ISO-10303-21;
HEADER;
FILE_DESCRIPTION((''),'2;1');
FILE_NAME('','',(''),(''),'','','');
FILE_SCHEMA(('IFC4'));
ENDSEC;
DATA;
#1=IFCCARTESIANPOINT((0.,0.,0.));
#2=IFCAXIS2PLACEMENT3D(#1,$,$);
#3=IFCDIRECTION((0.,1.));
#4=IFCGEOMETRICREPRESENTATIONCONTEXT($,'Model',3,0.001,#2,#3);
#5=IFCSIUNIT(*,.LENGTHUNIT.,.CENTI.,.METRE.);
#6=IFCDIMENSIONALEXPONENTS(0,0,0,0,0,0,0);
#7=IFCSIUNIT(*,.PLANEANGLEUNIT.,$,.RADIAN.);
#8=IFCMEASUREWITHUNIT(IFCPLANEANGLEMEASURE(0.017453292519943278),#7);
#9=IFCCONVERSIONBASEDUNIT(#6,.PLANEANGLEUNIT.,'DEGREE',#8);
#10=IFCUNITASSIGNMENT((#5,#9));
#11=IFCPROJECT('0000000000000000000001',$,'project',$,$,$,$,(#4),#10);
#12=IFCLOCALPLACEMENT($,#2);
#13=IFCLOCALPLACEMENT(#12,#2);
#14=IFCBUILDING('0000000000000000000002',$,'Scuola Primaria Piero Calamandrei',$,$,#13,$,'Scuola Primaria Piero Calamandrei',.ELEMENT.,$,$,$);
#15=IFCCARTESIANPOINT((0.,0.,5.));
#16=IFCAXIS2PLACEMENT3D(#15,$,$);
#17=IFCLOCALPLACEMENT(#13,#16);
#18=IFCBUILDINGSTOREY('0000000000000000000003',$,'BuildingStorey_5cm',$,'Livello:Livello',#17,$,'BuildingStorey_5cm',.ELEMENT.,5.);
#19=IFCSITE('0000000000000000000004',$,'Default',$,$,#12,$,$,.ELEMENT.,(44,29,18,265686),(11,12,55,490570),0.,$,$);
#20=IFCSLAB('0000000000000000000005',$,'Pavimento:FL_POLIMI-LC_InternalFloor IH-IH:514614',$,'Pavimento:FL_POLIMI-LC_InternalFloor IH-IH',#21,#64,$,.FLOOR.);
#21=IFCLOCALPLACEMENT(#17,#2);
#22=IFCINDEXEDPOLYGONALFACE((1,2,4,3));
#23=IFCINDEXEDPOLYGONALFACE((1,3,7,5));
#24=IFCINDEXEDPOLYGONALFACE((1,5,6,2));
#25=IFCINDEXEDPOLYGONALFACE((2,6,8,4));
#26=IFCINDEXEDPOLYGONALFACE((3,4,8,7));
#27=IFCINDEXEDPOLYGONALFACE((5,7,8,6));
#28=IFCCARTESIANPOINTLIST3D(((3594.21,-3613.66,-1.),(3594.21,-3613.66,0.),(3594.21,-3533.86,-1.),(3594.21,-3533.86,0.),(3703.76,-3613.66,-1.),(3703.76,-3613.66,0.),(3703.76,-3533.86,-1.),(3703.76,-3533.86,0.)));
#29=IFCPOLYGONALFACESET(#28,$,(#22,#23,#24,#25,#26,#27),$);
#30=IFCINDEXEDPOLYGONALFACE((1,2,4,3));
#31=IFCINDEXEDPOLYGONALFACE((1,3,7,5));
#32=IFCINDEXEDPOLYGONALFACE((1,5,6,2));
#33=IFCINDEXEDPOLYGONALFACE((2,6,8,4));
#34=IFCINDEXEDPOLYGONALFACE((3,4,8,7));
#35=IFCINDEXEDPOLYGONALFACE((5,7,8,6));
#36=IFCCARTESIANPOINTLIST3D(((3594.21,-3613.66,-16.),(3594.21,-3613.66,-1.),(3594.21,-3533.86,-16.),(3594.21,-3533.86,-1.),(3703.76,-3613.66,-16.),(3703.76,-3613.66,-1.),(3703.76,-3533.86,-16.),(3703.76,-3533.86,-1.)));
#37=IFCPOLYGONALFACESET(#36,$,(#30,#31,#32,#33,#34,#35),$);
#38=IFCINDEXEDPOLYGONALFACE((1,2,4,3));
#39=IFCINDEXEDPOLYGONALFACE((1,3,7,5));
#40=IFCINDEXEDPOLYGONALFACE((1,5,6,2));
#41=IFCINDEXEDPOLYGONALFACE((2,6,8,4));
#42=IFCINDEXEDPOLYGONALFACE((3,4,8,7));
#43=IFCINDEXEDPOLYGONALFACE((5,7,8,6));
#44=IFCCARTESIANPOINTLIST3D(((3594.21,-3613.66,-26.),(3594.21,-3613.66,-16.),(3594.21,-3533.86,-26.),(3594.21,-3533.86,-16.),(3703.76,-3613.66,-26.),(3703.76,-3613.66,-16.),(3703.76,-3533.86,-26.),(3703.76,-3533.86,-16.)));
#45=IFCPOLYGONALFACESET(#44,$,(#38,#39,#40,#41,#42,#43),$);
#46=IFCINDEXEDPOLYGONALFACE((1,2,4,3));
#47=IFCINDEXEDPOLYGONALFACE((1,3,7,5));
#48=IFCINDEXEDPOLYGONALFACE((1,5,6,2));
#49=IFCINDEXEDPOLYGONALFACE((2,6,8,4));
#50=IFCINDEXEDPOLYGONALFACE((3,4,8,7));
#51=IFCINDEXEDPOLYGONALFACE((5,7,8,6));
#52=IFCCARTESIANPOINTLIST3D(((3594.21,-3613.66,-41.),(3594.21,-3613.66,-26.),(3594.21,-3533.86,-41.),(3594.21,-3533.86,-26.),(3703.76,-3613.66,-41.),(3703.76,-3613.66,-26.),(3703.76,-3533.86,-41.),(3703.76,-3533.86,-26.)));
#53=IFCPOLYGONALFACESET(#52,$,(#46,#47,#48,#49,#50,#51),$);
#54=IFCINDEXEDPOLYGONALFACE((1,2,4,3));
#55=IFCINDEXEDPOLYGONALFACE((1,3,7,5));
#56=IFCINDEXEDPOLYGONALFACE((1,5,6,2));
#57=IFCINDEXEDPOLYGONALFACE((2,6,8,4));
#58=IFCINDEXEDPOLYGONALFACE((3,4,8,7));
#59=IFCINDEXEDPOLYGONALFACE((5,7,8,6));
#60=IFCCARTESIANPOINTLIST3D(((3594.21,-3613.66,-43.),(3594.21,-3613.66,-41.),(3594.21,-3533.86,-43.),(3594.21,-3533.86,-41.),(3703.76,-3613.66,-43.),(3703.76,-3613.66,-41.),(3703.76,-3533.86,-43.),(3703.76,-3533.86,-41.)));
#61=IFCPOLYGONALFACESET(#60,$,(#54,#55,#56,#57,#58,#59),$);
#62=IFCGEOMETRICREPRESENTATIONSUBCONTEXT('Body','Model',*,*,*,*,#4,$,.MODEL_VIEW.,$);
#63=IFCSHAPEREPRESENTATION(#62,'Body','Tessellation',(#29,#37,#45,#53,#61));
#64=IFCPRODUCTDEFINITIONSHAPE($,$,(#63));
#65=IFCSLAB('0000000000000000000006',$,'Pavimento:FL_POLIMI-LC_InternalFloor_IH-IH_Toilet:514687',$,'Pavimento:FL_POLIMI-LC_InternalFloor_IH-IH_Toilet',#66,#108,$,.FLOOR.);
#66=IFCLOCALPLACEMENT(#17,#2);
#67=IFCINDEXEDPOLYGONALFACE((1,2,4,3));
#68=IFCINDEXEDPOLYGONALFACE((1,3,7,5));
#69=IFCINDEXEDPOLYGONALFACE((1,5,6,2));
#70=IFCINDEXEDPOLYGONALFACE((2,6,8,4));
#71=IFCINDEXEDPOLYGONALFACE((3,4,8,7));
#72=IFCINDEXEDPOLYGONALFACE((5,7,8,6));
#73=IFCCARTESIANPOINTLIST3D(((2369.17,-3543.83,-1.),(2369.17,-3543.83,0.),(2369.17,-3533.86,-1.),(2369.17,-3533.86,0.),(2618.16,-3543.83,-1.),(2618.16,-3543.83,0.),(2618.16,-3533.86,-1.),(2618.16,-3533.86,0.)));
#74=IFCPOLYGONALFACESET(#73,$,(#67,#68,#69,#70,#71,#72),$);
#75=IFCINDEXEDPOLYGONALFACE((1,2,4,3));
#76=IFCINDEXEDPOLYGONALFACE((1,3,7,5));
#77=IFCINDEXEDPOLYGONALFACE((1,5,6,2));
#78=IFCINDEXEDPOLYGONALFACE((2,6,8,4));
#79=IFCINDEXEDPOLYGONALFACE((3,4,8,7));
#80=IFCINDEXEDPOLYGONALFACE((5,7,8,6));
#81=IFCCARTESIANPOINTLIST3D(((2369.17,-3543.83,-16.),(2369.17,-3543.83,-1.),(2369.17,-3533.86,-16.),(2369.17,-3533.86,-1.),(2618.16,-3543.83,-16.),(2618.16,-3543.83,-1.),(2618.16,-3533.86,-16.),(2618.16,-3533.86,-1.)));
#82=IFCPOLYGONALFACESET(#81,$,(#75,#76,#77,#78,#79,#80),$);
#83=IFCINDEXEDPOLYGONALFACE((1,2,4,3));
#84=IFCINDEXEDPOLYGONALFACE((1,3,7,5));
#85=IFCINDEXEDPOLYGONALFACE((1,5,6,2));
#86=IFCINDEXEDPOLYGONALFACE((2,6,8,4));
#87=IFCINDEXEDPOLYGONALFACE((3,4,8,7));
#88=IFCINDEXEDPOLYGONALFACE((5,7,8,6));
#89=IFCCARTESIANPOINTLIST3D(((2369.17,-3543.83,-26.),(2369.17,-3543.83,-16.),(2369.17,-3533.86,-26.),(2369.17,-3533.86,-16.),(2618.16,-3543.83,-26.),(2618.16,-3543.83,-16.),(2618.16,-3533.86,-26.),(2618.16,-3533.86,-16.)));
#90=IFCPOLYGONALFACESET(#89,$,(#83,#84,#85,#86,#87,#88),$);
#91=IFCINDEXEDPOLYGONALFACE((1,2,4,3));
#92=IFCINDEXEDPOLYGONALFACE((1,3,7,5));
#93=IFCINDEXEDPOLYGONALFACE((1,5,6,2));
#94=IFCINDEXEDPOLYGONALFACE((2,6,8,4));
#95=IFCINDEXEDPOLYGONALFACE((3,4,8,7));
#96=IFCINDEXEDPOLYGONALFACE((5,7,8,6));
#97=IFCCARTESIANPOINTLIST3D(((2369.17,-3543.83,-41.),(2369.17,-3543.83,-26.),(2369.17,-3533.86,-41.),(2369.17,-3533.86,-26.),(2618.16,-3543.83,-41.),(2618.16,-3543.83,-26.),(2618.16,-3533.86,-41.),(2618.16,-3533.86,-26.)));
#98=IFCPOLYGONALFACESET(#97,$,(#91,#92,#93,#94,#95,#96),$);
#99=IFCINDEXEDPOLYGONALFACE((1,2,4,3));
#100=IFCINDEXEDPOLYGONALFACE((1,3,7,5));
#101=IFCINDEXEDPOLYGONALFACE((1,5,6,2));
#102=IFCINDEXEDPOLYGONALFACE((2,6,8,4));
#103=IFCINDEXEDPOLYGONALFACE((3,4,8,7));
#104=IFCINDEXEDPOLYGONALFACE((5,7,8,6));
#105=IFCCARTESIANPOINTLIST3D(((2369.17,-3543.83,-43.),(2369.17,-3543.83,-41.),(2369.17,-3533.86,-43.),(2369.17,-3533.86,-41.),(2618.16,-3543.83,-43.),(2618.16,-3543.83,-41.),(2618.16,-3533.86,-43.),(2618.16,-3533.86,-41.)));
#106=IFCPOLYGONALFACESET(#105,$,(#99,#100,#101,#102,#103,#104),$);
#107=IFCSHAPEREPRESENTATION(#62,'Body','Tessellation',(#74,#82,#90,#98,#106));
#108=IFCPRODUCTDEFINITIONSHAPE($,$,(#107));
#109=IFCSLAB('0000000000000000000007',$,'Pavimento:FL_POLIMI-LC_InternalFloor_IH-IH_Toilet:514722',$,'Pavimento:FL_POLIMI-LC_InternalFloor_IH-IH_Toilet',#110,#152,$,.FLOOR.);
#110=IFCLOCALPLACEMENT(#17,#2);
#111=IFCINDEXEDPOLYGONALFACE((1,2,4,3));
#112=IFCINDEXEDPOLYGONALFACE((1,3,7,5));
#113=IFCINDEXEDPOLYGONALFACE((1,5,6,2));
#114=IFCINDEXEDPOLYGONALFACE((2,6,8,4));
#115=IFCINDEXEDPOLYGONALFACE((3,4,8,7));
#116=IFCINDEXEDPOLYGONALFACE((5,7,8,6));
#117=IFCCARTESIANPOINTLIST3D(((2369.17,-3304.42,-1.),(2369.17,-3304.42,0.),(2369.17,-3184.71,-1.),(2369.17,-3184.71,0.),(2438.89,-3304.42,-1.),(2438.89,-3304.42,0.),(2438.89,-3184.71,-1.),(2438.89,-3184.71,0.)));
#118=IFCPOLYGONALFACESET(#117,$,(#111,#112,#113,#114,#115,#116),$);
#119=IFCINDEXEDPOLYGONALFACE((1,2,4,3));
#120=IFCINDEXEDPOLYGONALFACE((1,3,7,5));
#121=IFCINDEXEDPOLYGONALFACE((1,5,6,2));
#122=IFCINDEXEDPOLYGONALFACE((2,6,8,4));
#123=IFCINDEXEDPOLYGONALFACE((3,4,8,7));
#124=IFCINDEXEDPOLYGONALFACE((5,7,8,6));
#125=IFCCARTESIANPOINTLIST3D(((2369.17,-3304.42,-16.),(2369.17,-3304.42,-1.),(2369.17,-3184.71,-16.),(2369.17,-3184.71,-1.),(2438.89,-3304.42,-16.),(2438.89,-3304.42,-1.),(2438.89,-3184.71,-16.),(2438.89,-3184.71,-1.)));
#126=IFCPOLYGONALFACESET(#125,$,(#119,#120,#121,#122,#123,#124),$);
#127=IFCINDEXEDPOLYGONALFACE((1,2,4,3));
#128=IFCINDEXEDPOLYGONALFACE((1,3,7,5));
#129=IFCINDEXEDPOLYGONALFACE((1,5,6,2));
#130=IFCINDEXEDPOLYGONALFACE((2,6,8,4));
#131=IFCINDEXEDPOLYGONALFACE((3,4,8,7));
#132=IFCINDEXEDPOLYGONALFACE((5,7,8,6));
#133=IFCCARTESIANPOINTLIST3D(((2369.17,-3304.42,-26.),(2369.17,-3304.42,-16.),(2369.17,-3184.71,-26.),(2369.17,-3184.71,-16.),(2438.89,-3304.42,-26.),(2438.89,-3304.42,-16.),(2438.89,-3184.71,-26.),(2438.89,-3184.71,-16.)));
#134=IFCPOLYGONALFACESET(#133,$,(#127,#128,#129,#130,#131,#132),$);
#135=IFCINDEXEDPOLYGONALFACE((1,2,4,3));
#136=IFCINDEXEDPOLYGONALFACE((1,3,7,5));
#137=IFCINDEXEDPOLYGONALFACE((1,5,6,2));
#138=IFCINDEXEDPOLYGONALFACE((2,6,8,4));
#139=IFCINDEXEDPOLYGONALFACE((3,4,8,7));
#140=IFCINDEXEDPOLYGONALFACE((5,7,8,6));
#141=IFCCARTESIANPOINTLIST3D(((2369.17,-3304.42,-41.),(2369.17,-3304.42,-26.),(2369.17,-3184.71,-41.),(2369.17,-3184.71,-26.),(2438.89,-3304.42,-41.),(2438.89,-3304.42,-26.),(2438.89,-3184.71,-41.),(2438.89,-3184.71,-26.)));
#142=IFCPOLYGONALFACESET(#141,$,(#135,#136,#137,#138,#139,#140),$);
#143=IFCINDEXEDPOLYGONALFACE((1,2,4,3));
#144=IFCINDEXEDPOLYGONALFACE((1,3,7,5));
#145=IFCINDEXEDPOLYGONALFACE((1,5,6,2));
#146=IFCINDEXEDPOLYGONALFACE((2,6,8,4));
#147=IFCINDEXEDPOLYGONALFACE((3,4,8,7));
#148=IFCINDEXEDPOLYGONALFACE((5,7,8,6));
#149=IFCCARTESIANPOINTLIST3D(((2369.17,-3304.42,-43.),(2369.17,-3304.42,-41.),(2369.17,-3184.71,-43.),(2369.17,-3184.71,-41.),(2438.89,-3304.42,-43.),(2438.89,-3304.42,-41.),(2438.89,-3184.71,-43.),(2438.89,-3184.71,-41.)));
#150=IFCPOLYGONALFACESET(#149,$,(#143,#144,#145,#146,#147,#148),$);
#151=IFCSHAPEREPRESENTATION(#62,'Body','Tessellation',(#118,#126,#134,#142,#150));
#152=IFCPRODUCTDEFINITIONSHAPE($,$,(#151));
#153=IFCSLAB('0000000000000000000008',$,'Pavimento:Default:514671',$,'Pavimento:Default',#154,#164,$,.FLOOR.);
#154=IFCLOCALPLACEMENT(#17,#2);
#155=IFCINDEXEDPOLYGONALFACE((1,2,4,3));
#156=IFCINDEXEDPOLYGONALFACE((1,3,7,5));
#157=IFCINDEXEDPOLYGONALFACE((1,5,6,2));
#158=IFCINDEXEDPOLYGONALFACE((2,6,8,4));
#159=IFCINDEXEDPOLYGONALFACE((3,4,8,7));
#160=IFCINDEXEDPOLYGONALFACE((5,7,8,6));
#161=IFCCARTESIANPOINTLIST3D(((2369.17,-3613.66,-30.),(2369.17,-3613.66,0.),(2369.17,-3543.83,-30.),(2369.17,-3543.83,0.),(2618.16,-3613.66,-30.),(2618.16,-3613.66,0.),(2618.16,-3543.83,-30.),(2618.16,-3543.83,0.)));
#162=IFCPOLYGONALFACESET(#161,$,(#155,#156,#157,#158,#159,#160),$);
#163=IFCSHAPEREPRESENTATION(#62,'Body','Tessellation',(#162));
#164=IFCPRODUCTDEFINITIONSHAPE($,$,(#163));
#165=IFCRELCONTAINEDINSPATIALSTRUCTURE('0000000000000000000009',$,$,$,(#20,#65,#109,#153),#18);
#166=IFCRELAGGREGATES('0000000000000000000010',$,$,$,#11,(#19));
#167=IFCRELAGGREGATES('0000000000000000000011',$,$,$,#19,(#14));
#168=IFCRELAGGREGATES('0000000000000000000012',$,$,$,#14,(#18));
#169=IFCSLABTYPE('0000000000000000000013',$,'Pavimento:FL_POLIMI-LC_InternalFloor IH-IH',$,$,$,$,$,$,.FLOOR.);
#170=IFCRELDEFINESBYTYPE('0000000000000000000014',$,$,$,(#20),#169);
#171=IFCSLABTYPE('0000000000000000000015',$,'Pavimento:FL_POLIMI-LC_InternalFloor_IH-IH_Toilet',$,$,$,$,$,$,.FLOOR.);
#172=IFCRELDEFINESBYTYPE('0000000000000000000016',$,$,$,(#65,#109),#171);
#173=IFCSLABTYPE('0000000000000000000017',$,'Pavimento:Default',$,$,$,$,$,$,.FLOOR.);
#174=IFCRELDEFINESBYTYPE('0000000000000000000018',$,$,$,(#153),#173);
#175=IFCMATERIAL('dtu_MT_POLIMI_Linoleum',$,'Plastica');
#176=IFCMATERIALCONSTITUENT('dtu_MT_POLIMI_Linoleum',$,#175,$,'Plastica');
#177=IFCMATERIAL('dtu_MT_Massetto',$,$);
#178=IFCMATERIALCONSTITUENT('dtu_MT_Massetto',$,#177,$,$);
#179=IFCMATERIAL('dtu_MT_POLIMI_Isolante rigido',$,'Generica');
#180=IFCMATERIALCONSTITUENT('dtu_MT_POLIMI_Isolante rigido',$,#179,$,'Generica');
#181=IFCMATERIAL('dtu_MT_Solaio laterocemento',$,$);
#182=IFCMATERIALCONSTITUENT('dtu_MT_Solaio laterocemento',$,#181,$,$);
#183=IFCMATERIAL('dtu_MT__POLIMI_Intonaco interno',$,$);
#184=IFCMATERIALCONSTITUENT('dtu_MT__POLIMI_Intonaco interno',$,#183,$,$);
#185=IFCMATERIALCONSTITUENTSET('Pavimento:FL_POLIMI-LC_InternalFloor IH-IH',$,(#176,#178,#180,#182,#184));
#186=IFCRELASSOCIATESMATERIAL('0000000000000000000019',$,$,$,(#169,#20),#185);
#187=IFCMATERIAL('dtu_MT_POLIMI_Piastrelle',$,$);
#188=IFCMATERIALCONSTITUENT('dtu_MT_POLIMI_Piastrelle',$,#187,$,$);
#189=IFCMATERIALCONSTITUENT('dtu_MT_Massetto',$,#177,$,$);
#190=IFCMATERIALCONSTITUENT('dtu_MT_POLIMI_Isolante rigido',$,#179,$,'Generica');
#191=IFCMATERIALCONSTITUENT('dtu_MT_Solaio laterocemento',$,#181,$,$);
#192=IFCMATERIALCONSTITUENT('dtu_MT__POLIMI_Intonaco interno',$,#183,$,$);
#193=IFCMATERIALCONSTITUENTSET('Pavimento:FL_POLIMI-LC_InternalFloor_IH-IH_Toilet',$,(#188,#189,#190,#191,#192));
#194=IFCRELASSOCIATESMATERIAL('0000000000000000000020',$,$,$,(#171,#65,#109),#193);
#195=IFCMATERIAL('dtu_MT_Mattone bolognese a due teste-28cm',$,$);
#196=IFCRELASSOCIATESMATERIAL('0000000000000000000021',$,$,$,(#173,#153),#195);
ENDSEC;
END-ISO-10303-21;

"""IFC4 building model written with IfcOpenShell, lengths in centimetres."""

from ifc_helpers import new_model, entity, si_unit, converted_unit, direction, frame, origin, place, context, subcontext, project, spatial, indexed_curve, outline, extrude, material, constituent, constituent_set, type_object, element, save


model = new_model("IFC4")

# Units and contexts
model_context = context("Model", 3, precision=0.001, world=origin(), true_north=direction((0.0, 1.0)))
body_context = subcontext(model_context, "Body", "Model", "MODEL_VIEW")
ifc_project = project(units=[si_unit("LENGTHUNIT", "METRE", prefix="CENTI"), converted_unit("PLANEANGLEUNIT", "DEGREE", entity("IfcPlaneAngleMeasure", 0.017453292519943278), si_unit("PLANEANGLEUNIT", "RADIAN"), dimensions=[0, 0, 0, 0, 0, 0, 0])], contexts=[model_context])

# Site, building, storey
site_placement = place(None, origin())
site = spatial("IfcSite", under=ifc_project, at=site_placement, Name="Default", CompositionType="ELEMENT", RefLatitude=(44, 29, 18, 265686), RefLongitude=(11, 12, 55, 490570), RefElevation=0.0)
building_placement = place(site_placement, origin())
building = spatial("IfcBuilding", under=site, at=building_placement, Name="Scuola Primaria Piero Calamandrei", LongName="Scuola Primaria Piero Calamandrei", CompositionType="ELEMENT")
storey_placement = place(building_placement, frame((0.0, 0.0, 5.0)))
storey = spatial("IfcBuildingStorey", under=building, at=storey_placement, Name="BuildingStorey_5cm", ObjectType="Livello:Livello", LongName="BuildingStorey_5cm", CompositionType="ELEMENT", Elevation=5.0)

# Slabs
ifc_material_1 = material(Name="dtu_MT_POLIMI_Linoleum", Category="Plastica")
ifc_constituent_1 = constituent(ifc_material_1, Name="dtu_MT_POLIMI_Linoleum", Category="Plastica")
ifc_material_2 = material(Name="dtu_MT_Massetto")
ifc_constituent_2 = constituent(ifc_material_2, Name="dtu_MT_Massetto")
ifc_material_3 = material(Name="dtu_MT_POLIMI_Isolante rigido", Category="Generica")
ifc_constituent_3 = constituent(ifc_material_3, Name="dtu_MT_POLIMI_Isolante rigido", Category="Generica")
ifc_material_4 = material(Name="dtu_MT_Solaio laterocemento")
ifc_constituent_4 = constituent(ifc_material_4, Name="dtu_MT_Solaio laterocemento")
ifc_material_5 = material(Name="dtu_MT__POLIMI_Intonaco interno")
ifc_constituent_5 = constituent(ifc_material_5, Name="dtu_MT__POLIMI_Intonaco interno")
ifc_constituent_set_1 = constituent_set(constituents=[ifc_constituent_1, ifc_constituent_2, ifc_constituent_3, ifc_constituent_4, ifc_constituent_5], Name="Pavimento:FL_POLIMI-LC_InternalFloor IH-IH")
slab_type_1 = type_object("IfcSlabType", Name="Pavimento:FL_POLIMI-LC_InternalFloor IH-IH", PredefinedType="FLOOR", material=ifc_constituent_set_1)
slab_1_placement = place(storey_placement, origin())
element("IfcSlab", 1, at=slab_1_placement, inside=storey, type_object=slab_type_1, material=ifc_constituent_set_1, Name="Pavimento:FL_POLIMI-LC_InternalFloor IH-IH:514614", ObjectType="Pavimento:FL_POLIMI-LC_InternalFloor IH-IH", PredefinedType="FLOOR", context=body_context, shape_type="SweptSolid", body=[
    extrude(outline(indexed_curve([(-39.9, -54.78), (39.9, -54.78), (39.9, 54.78), (-39.9, 54.78), (-39.9, -54.78)], self_intersect=False)), frame((3648.99, -3573.76, -1.0), z_axis=(0.0, 0.0, 1.0), x_axis=(0.0, -1.0, 0.0)), (0.0, 0.0, 1.0), 1.0),
    extrude(outline(indexed_curve([(-39.9, -54.78), (39.9, -54.78), (39.9, 54.78), (-39.9, 54.78), (-39.9, -54.78)], self_intersect=False)), frame((3648.99, -3573.76, -16.0), z_axis=(0.0, 0.0, 1.0), x_axis=(0.0, -1.0, 0.0)), (0.0, 0.0, 1.0), 15.0),
    extrude(outline(indexed_curve([(-39.9, -54.78), (39.9, -54.78), (39.9, 54.78), (-39.9, 54.78), (-39.9, -54.78)], self_intersect=False)), frame((3648.99, -3573.76, -26.0), z_axis=(0.0, 0.0, 1.0), x_axis=(0.0, -1.0, 0.0)), (0.0, 0.0, 1.0), 10.0),
    extrude(outline(indexed_curve([(-39.9, -54.78), (39.9, -54.78), (39.9, 54.78), (-39.9, 54.78), (-39.9, -54.78)], self_intersect=False)), frame((3648.99, -3573.76, -41.0), z_axis=(0.0, 0.0, 1.0), x_axis=(0.0, -1.0, 0.0)), (0.0, 0.0, 1.0), 15.0),
    extrude(outline(indexed_curve([(-39.9, -54.78), (39.9, -54.78), (39.9, 54.78), (-39.9, 54.78), (-39.9, -54.78)], self_intersect=False)), frame((3648.99, -3573.76, -43.0), z_axis=(0.0, 0.0, 1.0), x_axis=(0.0, -1.0, 0.0)), (0.0, 0.0, 1.0), 2.0),
])
ifc_material_6 = material(Name="dtu_MT_POLIMI_Piastrelle")
ifc_constituent_6 = constituent(ifc_material_6, Name="dtu_MT_POLIMI_Piastrelle")
ifc_constituent_7 = constituent(ifc_material_2, Name="dtu_MT_Massetto")
ifc_constituent_8 = constituent(ifc_material_3, Name="dtu_MT_POLIMI_Isolante rigido", Category="Generica")
ifc_constituent_9 = constituent(ifc_material_4, Name="dtu_MT_Solaio laterocemento")
ifc_constituent_10 = constituent(ifc_material_5, Name="dtu_MT__POLIMI_Intonaco interno")
ifc_constituent_set_2 = constituent_set(constituents=[ifc_constituent_6, ifc_constituent_7, ifc_constituent_8, ifc_constituent_9, ifc_constituent_10], Name="Pavimento:FL_POLIMI-LC_InternalFloor_IH-IH_Toilet")
slab_type_2 = type_object("IfcSlabType", Name="Pavimento:FL_POLIMI-LC_InternalFloor_IH-IH_Toilet", PredefinedType="FLOOR", material=ifc_constituent_set_2)
slab_2_placement = place(storey_placement, origin())
element("IfcSlab", 2, at=slab_2_placement, inside=storey, type_object=slab_type_2, material=ifc_constituent_set_2, Name="Pavimento:FL_POLIMI-LC_InternalFloor_IH-IH_Toilet:514687", ObjectType="Pavimento:FL_POLIMI-LC_InternalFloor_IH-IH_Toilet", PredefinedType="FLOOR", context=body_context, shape_type="SweptSolid", body=[
    extrude(outline(indexed_curve([(-4.99, -124.5), (4.99, -124.5), (4.99, 124.5), (-4.99, 124.5), (-4.99, -124.5)], self_intersect=False)), frame((2493.67, -3538.84, -1.0), z_axis=(0.0, 0.0, 1.0), x_axis=(0.0, -1.0, 0.0)), (0.0, 0.0, 1.0), 1.0),
    extrude(outline(indexed_curve([(-4.99, -124.5), (4.99, -124.5), (4.99, 124.5), (-4.99, 124.5), (-4.99, -124.5)], self_intersect=False)), frame((2493.67, -3538.84, -16.0), z_axis=(0.0, 0.0, 1.0), x_axis=(0.0, -1.0, 0.0)), (0.0, 0.0, 1.0), 15.0),
    extrude(outline(indexed_curve([(-4.99, -124.5), (4.99, -124.5), (4.99, 124.5), (-4.99, 124.5), (-4.99, -124.5)], self_intersect=False)), frame((2493.67, -3538.84, -26.0), z_axis=(0.0, 0.0, 1.0), x_axis=(0.0, -1.0, 0.0)), (0.0, 0.0, 1.0), 10.0),
    extrude(outline(indexed_curve([(-4.99, -124.5), (4.99, -124.5), (4.99, 124.5), (-4.99, 124.5), (-4.99, -124.5)], self_intersect=False)), frame((2493.67, -3538.84, -41.0), z_axis=(0.0, 0.0, 1.0), x_axis=(0.0, -1.0, 0.0)), (0.0, 0.0, 1.0), 15.0),
    extrude(outline(indexed_curve([(-4.99, -124.5), (4.99, -124.5), (4.99, 124.5), (-4.99, 124.5), (-4.99, -124.5)], self_intersect=False)), frame((2493.67, -3538.84, -43.0), z_axis=(0.0, 0.0, 1.0), x_axis=(0.0, -1.0, 0.0)), (0.0, 0.0, 1.0), 2.0),
])
slab_3_placement = place(storey_placement, origin())
element("IfcSlab", 3, at=slab_3_placement, inside=storey, type_object=slab_type_2, material=ifc_constituent_set_2, Name="Pavimento:FL_POLIMI-LC_InternalFloor_IH-IH_Toilet:514722", ObjectType="Pavimento:FL_POLIMI-LC_InternalFloor_IH-IH_Toilet", PredefinedType="FLOOR", context=body_context, shape_type="SweptSolid", body=[
    extrude(outline(indexed_curve([(-59.85, -34.86), (59.85, -34.86), (59.85, 34.86), (-59.85, 34.86), (-59.85, -34.86)], self_intersect=False)), frame((2404.03, -3244.57, -1.0), z_axis=(0.0, 0.0, 1.0), x_axis=(0.0, -1.0, 0.0)), (0.0, 0.0, 1.0), 1.0),
    extrude(outline(indexed_curve([(-59.85, -34.86), (59.85, -34.86), (59.85, 34.86), (-59.85, 34.86), (-59.85, -34.86)], self_intersect=False)), frame((2404.03, -3244.57, -16.0), z_axis=(0.0, 0.0, 1.0), x_axis=(0.0, -1.0, 0.0)), (0.0, 0.0, 1.0), 15.0),
    extrude(outline(indexed_curve([(-59.85, -34.86), (59.85, -34.86), (59.85, 34.86), (-59.85, 34.86), (-59.85, -34.86)], self_intersect=False)), frame((2404.03, -3244.57, -26.0), z_axis=(0.0, 0.0, 1.0), x_axis=(0.0, -1.0, 0.0)), (0.0, 0.0, 1.0), 10.0),
    extrude(outline(indexed_curve([(-59.85, -34.86), (59.85, -34.86), (59.85, 34.86), (-59.85, 34.86), (-59.85, -34.86)], self_intersect=False)), frame((2404.03, -3244.57, -41.0), z_axis=(0.0, 0.0, 1.0), x_axis=(0.0, -1.0, 0.0)), (0.0, 0.0, 1.0), 15.0),
    extrude(outline(indexed_curve([(-59.85, -34.86), (59.85, -34.86), (59.85, 34.86), (-59.85, 34.86), (-59.85, -34.86)], self_intersect=False)), frame((2404.03, -3244.57, -43.0), z_axis=(0.0, 0.0, 1.0), x_axis=(0.0, -1.0, 0.0)), (0.0, 0.0, 1.0), 2.0),
])
ifc_material_7 = material(Name="dtu_MT_Mattone bolognese a due teste-28cm")
slab_type_3 = type_object("IfcSlabType", Name="Pavimento:Default", PredefinedType="FLOOR", material=ifc_material_7)
slab_4_placement = place(storey_placement, origin())
element("IfcSlab", 4, at=slab_4_placement, inside=storey, type_object=slab_type_3, material=ifc_material_7, Name="Pavimento:Default:514671", ObjectType="Pavimento:Default", PredefinedType="FLOOR", context=body_context, shape_type="SweptSolid", body=[
    extrude(outline(indexed_curve([(-34.91, -124.5), (34.91, -124.5), (34.91, 124.5), (-34.91, 124.5), (-34.91, -124.5)], self_intersect=False)), frame((2493.67, -3578.75, 0.0), z_axis=(0.0, 0.0, -1.0), x_axis=(0.0, 1.0, 0.0)), (0.0, 0.0, 1.0), 30.0),
])

save(model, "model.ifc")
